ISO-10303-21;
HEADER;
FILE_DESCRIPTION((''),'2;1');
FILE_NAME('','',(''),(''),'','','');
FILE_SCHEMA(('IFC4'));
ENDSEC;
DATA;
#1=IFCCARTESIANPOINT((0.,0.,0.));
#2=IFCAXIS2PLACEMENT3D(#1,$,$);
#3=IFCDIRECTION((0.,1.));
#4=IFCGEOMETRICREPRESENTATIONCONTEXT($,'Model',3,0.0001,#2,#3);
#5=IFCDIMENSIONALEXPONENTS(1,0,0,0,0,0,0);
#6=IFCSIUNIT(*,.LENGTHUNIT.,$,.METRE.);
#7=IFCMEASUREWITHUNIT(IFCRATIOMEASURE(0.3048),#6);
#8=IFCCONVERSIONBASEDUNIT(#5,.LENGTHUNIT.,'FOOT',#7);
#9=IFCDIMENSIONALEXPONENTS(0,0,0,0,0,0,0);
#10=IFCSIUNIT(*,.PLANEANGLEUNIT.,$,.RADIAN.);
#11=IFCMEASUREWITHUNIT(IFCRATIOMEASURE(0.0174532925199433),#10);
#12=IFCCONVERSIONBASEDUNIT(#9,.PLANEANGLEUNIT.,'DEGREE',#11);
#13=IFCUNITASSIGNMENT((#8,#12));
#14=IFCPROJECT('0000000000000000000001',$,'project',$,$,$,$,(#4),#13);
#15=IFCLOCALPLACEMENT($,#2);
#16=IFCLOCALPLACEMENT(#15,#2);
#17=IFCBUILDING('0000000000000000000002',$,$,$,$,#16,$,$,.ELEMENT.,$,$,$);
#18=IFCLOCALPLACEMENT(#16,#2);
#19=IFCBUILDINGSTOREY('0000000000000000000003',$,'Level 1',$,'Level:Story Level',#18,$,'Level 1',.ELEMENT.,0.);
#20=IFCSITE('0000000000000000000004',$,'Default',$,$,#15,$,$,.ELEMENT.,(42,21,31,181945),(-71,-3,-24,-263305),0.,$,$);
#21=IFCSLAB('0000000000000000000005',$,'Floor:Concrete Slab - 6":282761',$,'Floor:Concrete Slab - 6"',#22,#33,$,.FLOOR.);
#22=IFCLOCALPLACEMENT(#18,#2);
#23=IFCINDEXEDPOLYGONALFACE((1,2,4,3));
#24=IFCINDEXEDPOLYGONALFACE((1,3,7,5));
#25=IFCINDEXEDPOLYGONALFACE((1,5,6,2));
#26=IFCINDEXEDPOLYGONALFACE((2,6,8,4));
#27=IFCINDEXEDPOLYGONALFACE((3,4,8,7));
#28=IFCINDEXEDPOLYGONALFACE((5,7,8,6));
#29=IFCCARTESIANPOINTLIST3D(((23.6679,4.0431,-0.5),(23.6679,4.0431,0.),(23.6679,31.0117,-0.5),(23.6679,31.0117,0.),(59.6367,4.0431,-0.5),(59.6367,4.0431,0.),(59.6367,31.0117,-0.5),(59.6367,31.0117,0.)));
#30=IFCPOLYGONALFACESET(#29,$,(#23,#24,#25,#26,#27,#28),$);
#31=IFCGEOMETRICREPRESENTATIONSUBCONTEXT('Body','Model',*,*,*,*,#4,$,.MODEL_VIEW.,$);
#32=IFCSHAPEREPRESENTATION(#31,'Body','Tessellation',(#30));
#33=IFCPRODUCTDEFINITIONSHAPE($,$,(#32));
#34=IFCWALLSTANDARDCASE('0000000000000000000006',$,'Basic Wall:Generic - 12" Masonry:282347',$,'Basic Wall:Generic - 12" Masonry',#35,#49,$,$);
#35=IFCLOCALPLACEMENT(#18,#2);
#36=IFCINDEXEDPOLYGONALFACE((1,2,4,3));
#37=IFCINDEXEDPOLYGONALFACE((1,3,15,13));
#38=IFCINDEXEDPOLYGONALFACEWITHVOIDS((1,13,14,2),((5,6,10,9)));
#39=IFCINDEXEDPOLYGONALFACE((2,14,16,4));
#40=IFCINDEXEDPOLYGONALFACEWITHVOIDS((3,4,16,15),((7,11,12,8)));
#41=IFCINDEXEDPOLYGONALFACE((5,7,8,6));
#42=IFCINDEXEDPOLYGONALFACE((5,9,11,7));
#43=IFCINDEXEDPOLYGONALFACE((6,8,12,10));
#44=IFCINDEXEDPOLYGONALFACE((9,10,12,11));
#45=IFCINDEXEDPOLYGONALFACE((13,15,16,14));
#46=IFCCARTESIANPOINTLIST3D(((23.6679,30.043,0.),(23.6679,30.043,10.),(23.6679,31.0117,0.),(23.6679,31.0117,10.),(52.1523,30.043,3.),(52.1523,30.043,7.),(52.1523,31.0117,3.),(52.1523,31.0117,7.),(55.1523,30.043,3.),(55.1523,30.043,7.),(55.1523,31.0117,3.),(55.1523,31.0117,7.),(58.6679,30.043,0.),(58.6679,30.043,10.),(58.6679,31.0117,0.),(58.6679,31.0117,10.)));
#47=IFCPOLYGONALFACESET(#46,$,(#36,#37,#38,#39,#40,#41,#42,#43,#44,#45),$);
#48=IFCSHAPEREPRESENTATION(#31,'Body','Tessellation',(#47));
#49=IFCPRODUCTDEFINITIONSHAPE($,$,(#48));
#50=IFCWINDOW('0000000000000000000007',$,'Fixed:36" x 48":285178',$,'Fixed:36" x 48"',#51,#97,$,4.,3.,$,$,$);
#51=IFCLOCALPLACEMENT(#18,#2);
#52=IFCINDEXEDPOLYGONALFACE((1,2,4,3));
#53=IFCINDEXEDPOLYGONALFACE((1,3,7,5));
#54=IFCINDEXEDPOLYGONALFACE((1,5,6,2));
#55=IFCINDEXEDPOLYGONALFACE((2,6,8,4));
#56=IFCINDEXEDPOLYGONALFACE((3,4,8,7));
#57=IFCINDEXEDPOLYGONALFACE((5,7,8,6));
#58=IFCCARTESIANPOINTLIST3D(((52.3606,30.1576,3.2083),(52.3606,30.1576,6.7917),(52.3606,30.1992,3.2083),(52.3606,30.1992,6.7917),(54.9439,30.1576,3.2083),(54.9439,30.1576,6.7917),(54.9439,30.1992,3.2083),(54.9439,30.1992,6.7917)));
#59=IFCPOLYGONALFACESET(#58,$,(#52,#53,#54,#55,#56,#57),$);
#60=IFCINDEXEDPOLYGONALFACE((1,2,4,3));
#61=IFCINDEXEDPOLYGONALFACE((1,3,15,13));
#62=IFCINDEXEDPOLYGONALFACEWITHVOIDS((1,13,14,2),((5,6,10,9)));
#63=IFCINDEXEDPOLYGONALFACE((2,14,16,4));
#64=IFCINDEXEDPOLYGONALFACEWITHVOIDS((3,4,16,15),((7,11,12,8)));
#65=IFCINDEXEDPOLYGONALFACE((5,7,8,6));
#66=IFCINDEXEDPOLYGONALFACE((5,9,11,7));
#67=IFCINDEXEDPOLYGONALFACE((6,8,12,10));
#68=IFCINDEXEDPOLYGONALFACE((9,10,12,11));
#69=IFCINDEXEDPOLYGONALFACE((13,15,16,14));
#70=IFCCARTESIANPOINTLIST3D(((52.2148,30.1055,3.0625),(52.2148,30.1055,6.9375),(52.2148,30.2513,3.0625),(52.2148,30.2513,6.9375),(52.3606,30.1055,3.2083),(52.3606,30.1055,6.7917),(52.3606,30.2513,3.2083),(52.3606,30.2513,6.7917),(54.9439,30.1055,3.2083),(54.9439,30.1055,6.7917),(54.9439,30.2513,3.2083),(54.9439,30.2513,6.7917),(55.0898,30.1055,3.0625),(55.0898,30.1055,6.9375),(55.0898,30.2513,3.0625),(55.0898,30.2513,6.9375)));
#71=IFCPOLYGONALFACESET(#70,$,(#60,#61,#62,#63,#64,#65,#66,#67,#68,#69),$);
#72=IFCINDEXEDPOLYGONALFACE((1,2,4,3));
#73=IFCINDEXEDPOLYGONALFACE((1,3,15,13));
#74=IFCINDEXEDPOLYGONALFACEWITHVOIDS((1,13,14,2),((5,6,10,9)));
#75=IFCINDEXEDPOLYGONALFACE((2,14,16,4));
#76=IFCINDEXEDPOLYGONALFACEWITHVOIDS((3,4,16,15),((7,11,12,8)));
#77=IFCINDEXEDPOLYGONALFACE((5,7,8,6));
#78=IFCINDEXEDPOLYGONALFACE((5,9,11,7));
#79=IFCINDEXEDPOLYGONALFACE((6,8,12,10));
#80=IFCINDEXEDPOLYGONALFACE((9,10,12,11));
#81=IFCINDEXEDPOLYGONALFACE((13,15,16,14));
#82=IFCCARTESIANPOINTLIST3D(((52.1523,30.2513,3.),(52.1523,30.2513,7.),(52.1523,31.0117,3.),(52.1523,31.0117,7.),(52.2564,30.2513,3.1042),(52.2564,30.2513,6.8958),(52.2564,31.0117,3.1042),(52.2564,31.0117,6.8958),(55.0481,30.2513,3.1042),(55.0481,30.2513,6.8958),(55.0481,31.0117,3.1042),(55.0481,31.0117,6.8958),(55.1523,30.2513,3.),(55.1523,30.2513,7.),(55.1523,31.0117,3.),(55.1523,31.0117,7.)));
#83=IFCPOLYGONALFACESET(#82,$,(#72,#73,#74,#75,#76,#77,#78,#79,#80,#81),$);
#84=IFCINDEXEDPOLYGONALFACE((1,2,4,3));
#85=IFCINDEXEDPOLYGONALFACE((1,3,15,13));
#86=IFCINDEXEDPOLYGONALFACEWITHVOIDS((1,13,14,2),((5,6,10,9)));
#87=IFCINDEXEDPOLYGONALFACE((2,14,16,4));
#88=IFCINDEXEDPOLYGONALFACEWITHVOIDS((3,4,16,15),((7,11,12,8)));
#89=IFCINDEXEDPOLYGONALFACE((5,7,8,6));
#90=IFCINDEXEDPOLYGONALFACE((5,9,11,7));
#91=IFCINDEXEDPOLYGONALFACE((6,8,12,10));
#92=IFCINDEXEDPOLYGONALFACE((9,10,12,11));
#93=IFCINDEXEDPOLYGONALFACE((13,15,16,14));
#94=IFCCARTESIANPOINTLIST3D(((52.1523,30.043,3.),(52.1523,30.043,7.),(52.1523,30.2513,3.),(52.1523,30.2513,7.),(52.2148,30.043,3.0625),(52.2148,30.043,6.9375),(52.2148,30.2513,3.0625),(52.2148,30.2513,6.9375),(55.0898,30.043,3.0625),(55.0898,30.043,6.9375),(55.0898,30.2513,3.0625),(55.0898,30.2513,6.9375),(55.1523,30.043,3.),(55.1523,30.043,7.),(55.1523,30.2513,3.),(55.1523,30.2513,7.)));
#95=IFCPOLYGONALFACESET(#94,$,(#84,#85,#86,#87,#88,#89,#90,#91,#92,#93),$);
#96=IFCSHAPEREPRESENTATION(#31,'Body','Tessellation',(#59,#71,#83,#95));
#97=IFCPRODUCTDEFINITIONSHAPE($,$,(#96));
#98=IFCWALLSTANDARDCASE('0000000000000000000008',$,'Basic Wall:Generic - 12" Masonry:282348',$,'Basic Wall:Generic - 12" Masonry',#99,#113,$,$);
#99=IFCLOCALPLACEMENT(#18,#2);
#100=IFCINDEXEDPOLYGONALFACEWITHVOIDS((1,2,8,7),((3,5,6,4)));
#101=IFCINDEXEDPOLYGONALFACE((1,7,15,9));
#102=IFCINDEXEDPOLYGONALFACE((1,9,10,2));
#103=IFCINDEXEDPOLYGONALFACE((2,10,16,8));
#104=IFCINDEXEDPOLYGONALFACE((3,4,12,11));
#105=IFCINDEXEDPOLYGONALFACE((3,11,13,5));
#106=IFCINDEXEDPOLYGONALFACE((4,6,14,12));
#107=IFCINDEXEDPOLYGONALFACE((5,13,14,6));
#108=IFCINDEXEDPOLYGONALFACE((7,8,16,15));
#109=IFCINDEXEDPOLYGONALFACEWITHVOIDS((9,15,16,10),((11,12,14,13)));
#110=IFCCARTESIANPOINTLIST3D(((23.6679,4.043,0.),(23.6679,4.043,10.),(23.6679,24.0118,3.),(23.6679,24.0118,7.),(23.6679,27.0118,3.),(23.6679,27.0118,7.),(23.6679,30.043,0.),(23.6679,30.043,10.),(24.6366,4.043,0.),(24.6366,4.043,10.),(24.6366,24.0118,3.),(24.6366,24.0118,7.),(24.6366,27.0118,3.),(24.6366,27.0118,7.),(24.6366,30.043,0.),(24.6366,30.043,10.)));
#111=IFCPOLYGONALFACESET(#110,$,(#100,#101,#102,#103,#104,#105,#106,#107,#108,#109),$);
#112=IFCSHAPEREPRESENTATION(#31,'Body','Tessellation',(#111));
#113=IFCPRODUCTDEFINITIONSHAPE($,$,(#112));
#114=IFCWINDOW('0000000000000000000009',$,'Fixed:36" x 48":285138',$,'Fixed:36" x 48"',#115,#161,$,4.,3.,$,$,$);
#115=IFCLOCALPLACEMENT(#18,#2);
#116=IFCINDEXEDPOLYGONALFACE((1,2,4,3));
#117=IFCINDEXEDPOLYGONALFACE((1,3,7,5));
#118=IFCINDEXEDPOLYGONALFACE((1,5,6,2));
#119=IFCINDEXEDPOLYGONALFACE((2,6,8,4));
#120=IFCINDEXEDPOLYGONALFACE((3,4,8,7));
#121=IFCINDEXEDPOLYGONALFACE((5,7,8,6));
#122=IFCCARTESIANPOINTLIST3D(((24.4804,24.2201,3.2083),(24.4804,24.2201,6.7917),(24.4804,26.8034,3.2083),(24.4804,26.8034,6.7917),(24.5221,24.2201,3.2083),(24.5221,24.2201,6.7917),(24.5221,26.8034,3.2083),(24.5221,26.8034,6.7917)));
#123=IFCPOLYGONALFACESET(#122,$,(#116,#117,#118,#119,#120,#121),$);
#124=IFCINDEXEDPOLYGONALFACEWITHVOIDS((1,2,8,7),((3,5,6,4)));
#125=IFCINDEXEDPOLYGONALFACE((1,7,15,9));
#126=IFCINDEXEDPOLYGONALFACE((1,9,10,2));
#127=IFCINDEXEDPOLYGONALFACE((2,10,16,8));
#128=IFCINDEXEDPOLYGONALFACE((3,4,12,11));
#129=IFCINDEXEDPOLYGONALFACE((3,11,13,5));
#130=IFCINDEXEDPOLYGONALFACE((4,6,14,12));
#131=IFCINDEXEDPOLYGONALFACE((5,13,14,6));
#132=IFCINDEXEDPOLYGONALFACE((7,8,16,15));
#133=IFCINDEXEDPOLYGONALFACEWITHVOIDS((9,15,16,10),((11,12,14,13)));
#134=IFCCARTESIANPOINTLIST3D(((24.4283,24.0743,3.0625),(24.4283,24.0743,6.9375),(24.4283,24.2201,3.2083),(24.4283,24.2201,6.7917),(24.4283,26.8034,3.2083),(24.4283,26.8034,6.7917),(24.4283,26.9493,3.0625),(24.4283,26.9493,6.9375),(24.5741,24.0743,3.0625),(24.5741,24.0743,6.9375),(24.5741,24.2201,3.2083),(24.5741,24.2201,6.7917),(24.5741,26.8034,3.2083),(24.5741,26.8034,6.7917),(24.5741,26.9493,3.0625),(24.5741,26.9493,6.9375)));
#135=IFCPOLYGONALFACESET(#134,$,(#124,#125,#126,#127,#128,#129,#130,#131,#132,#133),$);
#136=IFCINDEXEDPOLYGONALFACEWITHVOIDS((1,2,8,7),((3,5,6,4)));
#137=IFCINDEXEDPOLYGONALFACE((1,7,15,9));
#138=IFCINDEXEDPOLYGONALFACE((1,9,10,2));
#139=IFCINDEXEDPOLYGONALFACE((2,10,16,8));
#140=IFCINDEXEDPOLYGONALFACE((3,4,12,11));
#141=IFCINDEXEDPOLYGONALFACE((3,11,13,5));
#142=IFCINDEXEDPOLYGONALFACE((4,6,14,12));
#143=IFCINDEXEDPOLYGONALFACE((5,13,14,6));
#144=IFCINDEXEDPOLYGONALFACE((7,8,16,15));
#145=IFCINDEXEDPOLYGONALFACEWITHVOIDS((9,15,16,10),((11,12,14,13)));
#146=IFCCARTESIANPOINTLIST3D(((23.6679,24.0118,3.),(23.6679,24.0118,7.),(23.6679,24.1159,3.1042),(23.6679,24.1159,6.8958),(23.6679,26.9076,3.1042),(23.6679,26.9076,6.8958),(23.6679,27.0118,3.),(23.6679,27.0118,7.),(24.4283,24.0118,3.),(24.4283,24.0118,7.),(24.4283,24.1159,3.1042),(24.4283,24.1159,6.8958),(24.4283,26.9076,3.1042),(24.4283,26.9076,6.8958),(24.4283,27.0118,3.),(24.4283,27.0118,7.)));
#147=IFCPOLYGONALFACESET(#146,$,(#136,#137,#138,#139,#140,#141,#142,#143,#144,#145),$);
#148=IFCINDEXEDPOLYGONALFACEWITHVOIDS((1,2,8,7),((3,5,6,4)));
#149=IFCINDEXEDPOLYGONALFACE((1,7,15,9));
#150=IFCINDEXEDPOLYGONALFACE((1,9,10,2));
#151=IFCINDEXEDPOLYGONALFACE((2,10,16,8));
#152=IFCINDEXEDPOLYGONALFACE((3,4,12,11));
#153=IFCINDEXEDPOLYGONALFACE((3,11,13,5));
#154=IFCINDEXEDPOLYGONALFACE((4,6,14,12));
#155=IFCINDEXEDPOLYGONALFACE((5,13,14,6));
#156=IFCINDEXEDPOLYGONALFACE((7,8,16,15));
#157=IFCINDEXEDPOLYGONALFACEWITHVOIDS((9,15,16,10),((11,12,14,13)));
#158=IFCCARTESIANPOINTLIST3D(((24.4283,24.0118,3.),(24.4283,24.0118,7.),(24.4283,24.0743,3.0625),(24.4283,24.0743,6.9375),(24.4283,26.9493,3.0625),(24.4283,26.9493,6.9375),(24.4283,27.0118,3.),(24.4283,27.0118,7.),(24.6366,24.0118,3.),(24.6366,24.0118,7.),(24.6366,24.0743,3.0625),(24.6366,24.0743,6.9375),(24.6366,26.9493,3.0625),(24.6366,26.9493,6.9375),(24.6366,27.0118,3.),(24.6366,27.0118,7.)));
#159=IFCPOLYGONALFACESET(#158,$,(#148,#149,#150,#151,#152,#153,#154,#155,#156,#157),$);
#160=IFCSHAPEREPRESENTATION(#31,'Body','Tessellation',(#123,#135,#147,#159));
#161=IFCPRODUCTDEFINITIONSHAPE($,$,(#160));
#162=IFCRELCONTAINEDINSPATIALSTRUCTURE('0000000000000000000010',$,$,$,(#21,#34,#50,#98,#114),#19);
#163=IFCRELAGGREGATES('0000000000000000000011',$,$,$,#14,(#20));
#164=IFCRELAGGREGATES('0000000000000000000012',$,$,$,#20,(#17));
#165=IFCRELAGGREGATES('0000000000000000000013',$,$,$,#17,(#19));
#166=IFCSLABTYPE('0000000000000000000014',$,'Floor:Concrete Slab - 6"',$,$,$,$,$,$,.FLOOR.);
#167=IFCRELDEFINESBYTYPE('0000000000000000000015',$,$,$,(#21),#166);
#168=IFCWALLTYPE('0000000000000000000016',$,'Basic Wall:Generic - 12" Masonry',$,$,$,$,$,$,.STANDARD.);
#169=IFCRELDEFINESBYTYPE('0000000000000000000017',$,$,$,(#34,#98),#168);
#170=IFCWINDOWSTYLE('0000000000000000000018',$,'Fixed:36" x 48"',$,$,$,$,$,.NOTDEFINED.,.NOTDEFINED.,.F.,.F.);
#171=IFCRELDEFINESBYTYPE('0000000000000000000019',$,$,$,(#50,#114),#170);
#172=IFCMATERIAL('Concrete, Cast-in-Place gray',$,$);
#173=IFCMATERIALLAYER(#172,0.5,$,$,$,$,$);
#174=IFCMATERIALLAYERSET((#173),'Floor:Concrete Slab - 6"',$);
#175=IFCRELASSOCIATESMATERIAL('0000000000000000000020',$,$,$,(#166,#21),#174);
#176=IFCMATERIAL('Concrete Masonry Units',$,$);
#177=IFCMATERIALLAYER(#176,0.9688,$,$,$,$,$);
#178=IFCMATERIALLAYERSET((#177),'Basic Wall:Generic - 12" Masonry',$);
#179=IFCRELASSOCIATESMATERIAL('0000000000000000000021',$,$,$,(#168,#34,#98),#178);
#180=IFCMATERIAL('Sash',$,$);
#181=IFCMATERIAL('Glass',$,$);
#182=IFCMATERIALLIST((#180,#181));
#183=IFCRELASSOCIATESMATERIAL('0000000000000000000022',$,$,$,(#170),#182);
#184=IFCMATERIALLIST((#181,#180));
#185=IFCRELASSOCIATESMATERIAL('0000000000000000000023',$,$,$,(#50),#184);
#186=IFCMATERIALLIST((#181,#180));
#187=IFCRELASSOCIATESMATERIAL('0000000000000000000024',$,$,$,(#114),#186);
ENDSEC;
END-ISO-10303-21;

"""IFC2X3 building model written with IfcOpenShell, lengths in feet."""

from ifc_helpers import new_model, entity, si_unit, converted_unit, direction, frame, frame_2d, origin, place, context, subcontext, project, spatial, polyline, rectangle, outline, extrude, source, transform, mapped, material, material_list, layer, layer_set, layer_usage, type_object, type_shapes, element, fill, save


model = new_model("IFC2X3")

# Units and contexts
model_context = context("Model", 3, precision=0.0001, world=origin(), true_north=direction((0.0, 1.0)))
body_context = subcontext(model_context, "Body", "Model", "MODEL_VIEW")
ifc_project = project(units=[converted_unit("LENGTHUNIT", "FOOT", entity("IfcRatioMeasure", 0.3048), si_unit("LENGTHUNIT", "METRE"), dimensions=[1, 0, 0, 0, 0, 0, 0]), converted_unit("PLANEANGLEUNIT", "DEGREE", entity("IfcRatioMeasure", 0.0174532925199433), si_unit("PLANEANGLEUNIT", "RADIAN"), dimensions=[0, 0, 0, 0, 0, 0, 0])], contexts=[model_context])

# Site, building, storey
site_placement = place(None, origin())
site = spatial("IfcSite", under=ifc_project, at=site_placement, Name="Default", CompositionType="ELEMENT", RefLatitude=(42, 21, 31, 181945), RefLongitude=(-71, -3, -24, -263305), RefElevation=0.0)
building_placement = place(site_placement, origin())
building = spatial("IfcBuilding", under=site, at=building_placement, CompositionType="ELEMENT")
storey_placement = place(building_placement, origin())
storey = spatial("IfcBuildingStorey", under=building, at=storey_placement, Name="Level 1", ObjectType="Level:Story Level", LongName="Level 1", CompositionType="ELEMENT", Elevation=0.0)

# Slab
ifc_material_1 = material(Name="Concrete, Cast-in-Place gray")
ifc_layer_1 = layer(ifc_material_1, 0.5)
ifc_layer_set_1 = layer_set([ifc_layer_1], Name="Floor:Concrete Slab - 6\"")
ifc_layer_usage_1 = layer_usage(ifc_layer_set_1, "AXIS3", "POSITIVE", 0.0)
slab_type = type_object("IfcSlabType", Name="Floor:Concrete Slab - 6\"", PredefinedType="FLOOR", material=ifc_layer_set_1)
slab_placement = place(storey_placement, origin())
element("IfcSlab", 1, at=slab_placement, inside=storey, type_object=slab_type, material=ifc_layer_usage_1, Name="Floor:Concrete Slab - 6\":282761", ObjectType="Floor:Concrete Slab - 6\"", PredefinedType="FLOOR", context=body_context, shape_type="SweptSolid", body=[
    extrude(rectangle(XDim=26.9687, YDim=35.9688, at=frame_2d((0.0, 0.0), x_axis=(1.0, 0.0))), frame((41.6523, 17.5274, 0.0), z_axis=(0.0, 0.0, -1.0), x_axis=(0.0, 1.0, 0.0)), (0.0, 0.0, 1.0), 0.5),
])

# Walls, openings, windows
ifc_material_2 = material(Name="Concrete Masonry Units")
ifc_layer_2 = layer(ifc_material_2, 0.9688)
ifc_layer_set_2 = layer_set([ifc_layer_2], Name="Basic Wall:Generic - 12\" Masonry")
ifc_layer_usage_2 = layer_usage(ifc_layer_set_2, "AXIS2", "NEGATIVE", 0.4844)
wall_type = type_object("IfcWallType", Name="Basic Wall:Generic - 12\" Masonry", PredefinedType="STANDARD", material=ifc_layer_set_2)
wall_1_placement = place(storey_placement, frame((23.6679, 30.5274, 0.0)))
wall_1 = element("IfcWallStandardCase", 2, at=wall_1_placement, inside=storey, type_object=wall_type, material=ifc_layer_usage_2, Name="Basic Wall:Generic - 12\" Masonry:282347", ObjectType="Basic Wall:Generic - 12\" Masonry", context=body_context, shape_type="SweptSolid", body=[
    extrude(rectangle(XDim=35.0, YDim=0.9688, at=frame_2d((17.5, 0.0), x_axis=(-1.0, 0.0))), origin(), (0.0, 0.0, 1.0), 10.0),
])
opening_1_placement = place(wall_1_placement, frame((31.4844, 0.4844, 3.0)))
opening_1 = element("IfcOpeningElement", 3, at=opening_1_placement, cuts=wall_1, ObjectType="Opening", context=body_context, shape_type="SweptSolid", body=[
    extrude(rectangle(XDim=4.0, YDim=3.0, at=frame_2d((2.0, 1.5), x_axis=(-1.0, 0.0))), frame((0.0, 0.0, 0.0), z_axis=(0.0, -1.0, 0.0), x_axis=(0.0, 0.0, 1.0)), (0.0, 0.0, 1.0), 0.9688),
])
ifc_material_3 = material(Name="Glass")
ifc_material_4 = material(Name="Sash")
ifc_material_list_1 = material_list([ifc_material_3, ifc_material_4])
ifc_material_list_2 = material_list([ifc_material_4, ifc_material_3])
window_style = type_object("IfcWindowStyle", Name="Fixed:36\" x 48\"", ConstructionType="NOTDEFINED", OperationType="NOTDEFINED", ParameterTakesPrecedence=False, Sizeable=False, material=ifc_material_list_2)
shared_shape_1 = source(origin(), body_context, "Body", "SweptSolid", [
    extrude(rectangle(XDim=0.0417, YDim=2.5833, at=frame_2d((0.0, 0.0), x_axis=(1.0, 0.0))), frame((1.5, 0.8333, 0.2083), z_axis=(0.0, 0.0, 1.0), x_axis=(0.0, 1.0, 0.0)), (0.0, 0.0, 1.0), 3.5833),
    extrude(outline(polyline([(-1.4375, -1.9375), (1.4375, -1.9375), (1.4375, 1.9375), (-1.4375, 1.9375), (-1.4375, -1.9375)]), holes=[polyline([(-1.2917, -1.7917), (-1.2917, 1.7917), (1.2917, 1.7917), (1.2917, -1.7917), (-1.2917, -1.7917)])]), frame((1.5, 0.7604, 2.0), z_axis=(0.0, 1.0, 0.0), x_axis=(1.0, 0.0, 0.0)), (0.0, 0.0, 1.0), 0.1458),
    extrude(outline(polyline([(-1.5, -2.0), (1.5, -2.0), (1.5, 2.0), (-1.5, 2.0), (-1.5, -2.0)]), holes=[polyline([(-1.3958, -1.8958), (-1.3958, 1.8958), (1.3958, 1.8958), (1.3958, -1.8958), (-1.3958, -1.8958)])]), frame((1.5, 0.0, 2.0), z_axis=(0.0, 1.0, 0.0), x_axis=(1.0, 0.0, 0.0)), (0.0, 0.0, 1.0), 0.7604),
    extrude(outline(polyline([(-2.0, -1.5), (2.0, -1.5), (2.0, 1.5), (-2.0, 1.5), (-2.0, -1.5)]), holes=[polyline([(-1.9375, -1.4375), (-1.9375, 1.4375), (1.9375, 1.4375), (1.9375, -1.4375), (-1.9375, -1.4375)])]), frame((1.5, 0.7604, 2.0), z_axis=(0.0, 1.0, 0.0), x_axis=(0.0, 0.0, -1.0)), (0.0, 0.0, 1.0), 0.2083),
])
type_shapes(window_style, [shared_shape_1])
window_1_placement = place(opening_1_placement, frame((0.0, 0.0, 0.0), z_axis=(0.0, 0.0, 1.0), x_axis=(-1.0, 0.0, 0.0)))
window_1 = element("IfcWindow", 4, at=window_1_placement, inside=storey, type_object=window_style, material=ifc_material_list_1, Name="Fixed:36\" x 48\":285178", ObjectType="Fixed:36\" x 48\"", OverallHeight=4.0, OverallWidth=3.0, context=body_context, shape_type="MappedRepresentation", body=[
    mapped(shared_shape_1, transform((0.0, 0.0, 0.0), scale=1.0)),
])
fill(opening_1, window_1)
ifc_layer_usage_3 = layer_usage(ifc_layer_set_2, "AXIS2", "NEGATIVE", 0.4844)
wall_2_placement = place(storey_placement, frame((24.1523, 4.043, 0.0), z_axis=(0.0, 0.0, 1.0), x_axis=(0.0, 1.0, 0.0)))
wall_2 = element("IfcWallStandardCase", 5, at=wall_2_placement, inside=storey, type_object=wall_type, material=ifc_layer_usage_3, Name="Basic Wall:Generic - 12\" Masonry:282348", ObjectType="Basic Wall:Generic - 12\" Masonry", context=body_context, shape_type="SweptSolid", body=[
    extrude(rectangle(XDim=26.0, YDim=0.9688, at=frame_2d((13.0, 0.0), x_axis=(-1.0, 0.0))), origin(), (0.0, 0.0, 1.0), 10.0),
])
opening_2_placement = place(wall_2_placement, frame((22.9688, 0.4844, 3.0)))
opening_2 = element("IfcOpeningElement", 6, at=opening_2_placement, cuts=wall_2, ObjectType="Opening", context=body_context, shape_type="SweptSolid", body=[
    extrude(rectangle(XDim=4.0, YDim=3.0, at=frame_2d((2.0, 1.5), x_axis=(-1.0, 0.0))), frame((0.0, 0.0, 0.0), z_axis=(0.0, -1.0, 0.0), x_axis=(0.0, 0.0, 1.0)), (0.0, 0.0, 1.0), 0.9688),
])
ifc_material_list_3 = material_list([ifc_material_3, ifc_material_4])
window_2_placement = place(opening_2_placement, frame((0.0, 0.0, 0.0), z_axis=(0.0, 0.0, 1.0), x_axis=(-1.0, 0.0, 0.0)))
window_2 = element("IfcWindow", 7, at=window_2_placement, inside=storey, type_object=window_style, material=ifc_material_list_3, Name="Fixed:36\" x 48\":285138", ObjectType="Fixed:36\" x 48\"", OverallHeight=4.0, OverallWidth=3.0, context=body_context, shape_type="MappedRepresentation", body=[
    mapped(shared_shape_1, transform((0.0, 0.0, 0.0), scale=1.0)),
])
fill(opening_2, window_2)

save(model, "model.ifc")
